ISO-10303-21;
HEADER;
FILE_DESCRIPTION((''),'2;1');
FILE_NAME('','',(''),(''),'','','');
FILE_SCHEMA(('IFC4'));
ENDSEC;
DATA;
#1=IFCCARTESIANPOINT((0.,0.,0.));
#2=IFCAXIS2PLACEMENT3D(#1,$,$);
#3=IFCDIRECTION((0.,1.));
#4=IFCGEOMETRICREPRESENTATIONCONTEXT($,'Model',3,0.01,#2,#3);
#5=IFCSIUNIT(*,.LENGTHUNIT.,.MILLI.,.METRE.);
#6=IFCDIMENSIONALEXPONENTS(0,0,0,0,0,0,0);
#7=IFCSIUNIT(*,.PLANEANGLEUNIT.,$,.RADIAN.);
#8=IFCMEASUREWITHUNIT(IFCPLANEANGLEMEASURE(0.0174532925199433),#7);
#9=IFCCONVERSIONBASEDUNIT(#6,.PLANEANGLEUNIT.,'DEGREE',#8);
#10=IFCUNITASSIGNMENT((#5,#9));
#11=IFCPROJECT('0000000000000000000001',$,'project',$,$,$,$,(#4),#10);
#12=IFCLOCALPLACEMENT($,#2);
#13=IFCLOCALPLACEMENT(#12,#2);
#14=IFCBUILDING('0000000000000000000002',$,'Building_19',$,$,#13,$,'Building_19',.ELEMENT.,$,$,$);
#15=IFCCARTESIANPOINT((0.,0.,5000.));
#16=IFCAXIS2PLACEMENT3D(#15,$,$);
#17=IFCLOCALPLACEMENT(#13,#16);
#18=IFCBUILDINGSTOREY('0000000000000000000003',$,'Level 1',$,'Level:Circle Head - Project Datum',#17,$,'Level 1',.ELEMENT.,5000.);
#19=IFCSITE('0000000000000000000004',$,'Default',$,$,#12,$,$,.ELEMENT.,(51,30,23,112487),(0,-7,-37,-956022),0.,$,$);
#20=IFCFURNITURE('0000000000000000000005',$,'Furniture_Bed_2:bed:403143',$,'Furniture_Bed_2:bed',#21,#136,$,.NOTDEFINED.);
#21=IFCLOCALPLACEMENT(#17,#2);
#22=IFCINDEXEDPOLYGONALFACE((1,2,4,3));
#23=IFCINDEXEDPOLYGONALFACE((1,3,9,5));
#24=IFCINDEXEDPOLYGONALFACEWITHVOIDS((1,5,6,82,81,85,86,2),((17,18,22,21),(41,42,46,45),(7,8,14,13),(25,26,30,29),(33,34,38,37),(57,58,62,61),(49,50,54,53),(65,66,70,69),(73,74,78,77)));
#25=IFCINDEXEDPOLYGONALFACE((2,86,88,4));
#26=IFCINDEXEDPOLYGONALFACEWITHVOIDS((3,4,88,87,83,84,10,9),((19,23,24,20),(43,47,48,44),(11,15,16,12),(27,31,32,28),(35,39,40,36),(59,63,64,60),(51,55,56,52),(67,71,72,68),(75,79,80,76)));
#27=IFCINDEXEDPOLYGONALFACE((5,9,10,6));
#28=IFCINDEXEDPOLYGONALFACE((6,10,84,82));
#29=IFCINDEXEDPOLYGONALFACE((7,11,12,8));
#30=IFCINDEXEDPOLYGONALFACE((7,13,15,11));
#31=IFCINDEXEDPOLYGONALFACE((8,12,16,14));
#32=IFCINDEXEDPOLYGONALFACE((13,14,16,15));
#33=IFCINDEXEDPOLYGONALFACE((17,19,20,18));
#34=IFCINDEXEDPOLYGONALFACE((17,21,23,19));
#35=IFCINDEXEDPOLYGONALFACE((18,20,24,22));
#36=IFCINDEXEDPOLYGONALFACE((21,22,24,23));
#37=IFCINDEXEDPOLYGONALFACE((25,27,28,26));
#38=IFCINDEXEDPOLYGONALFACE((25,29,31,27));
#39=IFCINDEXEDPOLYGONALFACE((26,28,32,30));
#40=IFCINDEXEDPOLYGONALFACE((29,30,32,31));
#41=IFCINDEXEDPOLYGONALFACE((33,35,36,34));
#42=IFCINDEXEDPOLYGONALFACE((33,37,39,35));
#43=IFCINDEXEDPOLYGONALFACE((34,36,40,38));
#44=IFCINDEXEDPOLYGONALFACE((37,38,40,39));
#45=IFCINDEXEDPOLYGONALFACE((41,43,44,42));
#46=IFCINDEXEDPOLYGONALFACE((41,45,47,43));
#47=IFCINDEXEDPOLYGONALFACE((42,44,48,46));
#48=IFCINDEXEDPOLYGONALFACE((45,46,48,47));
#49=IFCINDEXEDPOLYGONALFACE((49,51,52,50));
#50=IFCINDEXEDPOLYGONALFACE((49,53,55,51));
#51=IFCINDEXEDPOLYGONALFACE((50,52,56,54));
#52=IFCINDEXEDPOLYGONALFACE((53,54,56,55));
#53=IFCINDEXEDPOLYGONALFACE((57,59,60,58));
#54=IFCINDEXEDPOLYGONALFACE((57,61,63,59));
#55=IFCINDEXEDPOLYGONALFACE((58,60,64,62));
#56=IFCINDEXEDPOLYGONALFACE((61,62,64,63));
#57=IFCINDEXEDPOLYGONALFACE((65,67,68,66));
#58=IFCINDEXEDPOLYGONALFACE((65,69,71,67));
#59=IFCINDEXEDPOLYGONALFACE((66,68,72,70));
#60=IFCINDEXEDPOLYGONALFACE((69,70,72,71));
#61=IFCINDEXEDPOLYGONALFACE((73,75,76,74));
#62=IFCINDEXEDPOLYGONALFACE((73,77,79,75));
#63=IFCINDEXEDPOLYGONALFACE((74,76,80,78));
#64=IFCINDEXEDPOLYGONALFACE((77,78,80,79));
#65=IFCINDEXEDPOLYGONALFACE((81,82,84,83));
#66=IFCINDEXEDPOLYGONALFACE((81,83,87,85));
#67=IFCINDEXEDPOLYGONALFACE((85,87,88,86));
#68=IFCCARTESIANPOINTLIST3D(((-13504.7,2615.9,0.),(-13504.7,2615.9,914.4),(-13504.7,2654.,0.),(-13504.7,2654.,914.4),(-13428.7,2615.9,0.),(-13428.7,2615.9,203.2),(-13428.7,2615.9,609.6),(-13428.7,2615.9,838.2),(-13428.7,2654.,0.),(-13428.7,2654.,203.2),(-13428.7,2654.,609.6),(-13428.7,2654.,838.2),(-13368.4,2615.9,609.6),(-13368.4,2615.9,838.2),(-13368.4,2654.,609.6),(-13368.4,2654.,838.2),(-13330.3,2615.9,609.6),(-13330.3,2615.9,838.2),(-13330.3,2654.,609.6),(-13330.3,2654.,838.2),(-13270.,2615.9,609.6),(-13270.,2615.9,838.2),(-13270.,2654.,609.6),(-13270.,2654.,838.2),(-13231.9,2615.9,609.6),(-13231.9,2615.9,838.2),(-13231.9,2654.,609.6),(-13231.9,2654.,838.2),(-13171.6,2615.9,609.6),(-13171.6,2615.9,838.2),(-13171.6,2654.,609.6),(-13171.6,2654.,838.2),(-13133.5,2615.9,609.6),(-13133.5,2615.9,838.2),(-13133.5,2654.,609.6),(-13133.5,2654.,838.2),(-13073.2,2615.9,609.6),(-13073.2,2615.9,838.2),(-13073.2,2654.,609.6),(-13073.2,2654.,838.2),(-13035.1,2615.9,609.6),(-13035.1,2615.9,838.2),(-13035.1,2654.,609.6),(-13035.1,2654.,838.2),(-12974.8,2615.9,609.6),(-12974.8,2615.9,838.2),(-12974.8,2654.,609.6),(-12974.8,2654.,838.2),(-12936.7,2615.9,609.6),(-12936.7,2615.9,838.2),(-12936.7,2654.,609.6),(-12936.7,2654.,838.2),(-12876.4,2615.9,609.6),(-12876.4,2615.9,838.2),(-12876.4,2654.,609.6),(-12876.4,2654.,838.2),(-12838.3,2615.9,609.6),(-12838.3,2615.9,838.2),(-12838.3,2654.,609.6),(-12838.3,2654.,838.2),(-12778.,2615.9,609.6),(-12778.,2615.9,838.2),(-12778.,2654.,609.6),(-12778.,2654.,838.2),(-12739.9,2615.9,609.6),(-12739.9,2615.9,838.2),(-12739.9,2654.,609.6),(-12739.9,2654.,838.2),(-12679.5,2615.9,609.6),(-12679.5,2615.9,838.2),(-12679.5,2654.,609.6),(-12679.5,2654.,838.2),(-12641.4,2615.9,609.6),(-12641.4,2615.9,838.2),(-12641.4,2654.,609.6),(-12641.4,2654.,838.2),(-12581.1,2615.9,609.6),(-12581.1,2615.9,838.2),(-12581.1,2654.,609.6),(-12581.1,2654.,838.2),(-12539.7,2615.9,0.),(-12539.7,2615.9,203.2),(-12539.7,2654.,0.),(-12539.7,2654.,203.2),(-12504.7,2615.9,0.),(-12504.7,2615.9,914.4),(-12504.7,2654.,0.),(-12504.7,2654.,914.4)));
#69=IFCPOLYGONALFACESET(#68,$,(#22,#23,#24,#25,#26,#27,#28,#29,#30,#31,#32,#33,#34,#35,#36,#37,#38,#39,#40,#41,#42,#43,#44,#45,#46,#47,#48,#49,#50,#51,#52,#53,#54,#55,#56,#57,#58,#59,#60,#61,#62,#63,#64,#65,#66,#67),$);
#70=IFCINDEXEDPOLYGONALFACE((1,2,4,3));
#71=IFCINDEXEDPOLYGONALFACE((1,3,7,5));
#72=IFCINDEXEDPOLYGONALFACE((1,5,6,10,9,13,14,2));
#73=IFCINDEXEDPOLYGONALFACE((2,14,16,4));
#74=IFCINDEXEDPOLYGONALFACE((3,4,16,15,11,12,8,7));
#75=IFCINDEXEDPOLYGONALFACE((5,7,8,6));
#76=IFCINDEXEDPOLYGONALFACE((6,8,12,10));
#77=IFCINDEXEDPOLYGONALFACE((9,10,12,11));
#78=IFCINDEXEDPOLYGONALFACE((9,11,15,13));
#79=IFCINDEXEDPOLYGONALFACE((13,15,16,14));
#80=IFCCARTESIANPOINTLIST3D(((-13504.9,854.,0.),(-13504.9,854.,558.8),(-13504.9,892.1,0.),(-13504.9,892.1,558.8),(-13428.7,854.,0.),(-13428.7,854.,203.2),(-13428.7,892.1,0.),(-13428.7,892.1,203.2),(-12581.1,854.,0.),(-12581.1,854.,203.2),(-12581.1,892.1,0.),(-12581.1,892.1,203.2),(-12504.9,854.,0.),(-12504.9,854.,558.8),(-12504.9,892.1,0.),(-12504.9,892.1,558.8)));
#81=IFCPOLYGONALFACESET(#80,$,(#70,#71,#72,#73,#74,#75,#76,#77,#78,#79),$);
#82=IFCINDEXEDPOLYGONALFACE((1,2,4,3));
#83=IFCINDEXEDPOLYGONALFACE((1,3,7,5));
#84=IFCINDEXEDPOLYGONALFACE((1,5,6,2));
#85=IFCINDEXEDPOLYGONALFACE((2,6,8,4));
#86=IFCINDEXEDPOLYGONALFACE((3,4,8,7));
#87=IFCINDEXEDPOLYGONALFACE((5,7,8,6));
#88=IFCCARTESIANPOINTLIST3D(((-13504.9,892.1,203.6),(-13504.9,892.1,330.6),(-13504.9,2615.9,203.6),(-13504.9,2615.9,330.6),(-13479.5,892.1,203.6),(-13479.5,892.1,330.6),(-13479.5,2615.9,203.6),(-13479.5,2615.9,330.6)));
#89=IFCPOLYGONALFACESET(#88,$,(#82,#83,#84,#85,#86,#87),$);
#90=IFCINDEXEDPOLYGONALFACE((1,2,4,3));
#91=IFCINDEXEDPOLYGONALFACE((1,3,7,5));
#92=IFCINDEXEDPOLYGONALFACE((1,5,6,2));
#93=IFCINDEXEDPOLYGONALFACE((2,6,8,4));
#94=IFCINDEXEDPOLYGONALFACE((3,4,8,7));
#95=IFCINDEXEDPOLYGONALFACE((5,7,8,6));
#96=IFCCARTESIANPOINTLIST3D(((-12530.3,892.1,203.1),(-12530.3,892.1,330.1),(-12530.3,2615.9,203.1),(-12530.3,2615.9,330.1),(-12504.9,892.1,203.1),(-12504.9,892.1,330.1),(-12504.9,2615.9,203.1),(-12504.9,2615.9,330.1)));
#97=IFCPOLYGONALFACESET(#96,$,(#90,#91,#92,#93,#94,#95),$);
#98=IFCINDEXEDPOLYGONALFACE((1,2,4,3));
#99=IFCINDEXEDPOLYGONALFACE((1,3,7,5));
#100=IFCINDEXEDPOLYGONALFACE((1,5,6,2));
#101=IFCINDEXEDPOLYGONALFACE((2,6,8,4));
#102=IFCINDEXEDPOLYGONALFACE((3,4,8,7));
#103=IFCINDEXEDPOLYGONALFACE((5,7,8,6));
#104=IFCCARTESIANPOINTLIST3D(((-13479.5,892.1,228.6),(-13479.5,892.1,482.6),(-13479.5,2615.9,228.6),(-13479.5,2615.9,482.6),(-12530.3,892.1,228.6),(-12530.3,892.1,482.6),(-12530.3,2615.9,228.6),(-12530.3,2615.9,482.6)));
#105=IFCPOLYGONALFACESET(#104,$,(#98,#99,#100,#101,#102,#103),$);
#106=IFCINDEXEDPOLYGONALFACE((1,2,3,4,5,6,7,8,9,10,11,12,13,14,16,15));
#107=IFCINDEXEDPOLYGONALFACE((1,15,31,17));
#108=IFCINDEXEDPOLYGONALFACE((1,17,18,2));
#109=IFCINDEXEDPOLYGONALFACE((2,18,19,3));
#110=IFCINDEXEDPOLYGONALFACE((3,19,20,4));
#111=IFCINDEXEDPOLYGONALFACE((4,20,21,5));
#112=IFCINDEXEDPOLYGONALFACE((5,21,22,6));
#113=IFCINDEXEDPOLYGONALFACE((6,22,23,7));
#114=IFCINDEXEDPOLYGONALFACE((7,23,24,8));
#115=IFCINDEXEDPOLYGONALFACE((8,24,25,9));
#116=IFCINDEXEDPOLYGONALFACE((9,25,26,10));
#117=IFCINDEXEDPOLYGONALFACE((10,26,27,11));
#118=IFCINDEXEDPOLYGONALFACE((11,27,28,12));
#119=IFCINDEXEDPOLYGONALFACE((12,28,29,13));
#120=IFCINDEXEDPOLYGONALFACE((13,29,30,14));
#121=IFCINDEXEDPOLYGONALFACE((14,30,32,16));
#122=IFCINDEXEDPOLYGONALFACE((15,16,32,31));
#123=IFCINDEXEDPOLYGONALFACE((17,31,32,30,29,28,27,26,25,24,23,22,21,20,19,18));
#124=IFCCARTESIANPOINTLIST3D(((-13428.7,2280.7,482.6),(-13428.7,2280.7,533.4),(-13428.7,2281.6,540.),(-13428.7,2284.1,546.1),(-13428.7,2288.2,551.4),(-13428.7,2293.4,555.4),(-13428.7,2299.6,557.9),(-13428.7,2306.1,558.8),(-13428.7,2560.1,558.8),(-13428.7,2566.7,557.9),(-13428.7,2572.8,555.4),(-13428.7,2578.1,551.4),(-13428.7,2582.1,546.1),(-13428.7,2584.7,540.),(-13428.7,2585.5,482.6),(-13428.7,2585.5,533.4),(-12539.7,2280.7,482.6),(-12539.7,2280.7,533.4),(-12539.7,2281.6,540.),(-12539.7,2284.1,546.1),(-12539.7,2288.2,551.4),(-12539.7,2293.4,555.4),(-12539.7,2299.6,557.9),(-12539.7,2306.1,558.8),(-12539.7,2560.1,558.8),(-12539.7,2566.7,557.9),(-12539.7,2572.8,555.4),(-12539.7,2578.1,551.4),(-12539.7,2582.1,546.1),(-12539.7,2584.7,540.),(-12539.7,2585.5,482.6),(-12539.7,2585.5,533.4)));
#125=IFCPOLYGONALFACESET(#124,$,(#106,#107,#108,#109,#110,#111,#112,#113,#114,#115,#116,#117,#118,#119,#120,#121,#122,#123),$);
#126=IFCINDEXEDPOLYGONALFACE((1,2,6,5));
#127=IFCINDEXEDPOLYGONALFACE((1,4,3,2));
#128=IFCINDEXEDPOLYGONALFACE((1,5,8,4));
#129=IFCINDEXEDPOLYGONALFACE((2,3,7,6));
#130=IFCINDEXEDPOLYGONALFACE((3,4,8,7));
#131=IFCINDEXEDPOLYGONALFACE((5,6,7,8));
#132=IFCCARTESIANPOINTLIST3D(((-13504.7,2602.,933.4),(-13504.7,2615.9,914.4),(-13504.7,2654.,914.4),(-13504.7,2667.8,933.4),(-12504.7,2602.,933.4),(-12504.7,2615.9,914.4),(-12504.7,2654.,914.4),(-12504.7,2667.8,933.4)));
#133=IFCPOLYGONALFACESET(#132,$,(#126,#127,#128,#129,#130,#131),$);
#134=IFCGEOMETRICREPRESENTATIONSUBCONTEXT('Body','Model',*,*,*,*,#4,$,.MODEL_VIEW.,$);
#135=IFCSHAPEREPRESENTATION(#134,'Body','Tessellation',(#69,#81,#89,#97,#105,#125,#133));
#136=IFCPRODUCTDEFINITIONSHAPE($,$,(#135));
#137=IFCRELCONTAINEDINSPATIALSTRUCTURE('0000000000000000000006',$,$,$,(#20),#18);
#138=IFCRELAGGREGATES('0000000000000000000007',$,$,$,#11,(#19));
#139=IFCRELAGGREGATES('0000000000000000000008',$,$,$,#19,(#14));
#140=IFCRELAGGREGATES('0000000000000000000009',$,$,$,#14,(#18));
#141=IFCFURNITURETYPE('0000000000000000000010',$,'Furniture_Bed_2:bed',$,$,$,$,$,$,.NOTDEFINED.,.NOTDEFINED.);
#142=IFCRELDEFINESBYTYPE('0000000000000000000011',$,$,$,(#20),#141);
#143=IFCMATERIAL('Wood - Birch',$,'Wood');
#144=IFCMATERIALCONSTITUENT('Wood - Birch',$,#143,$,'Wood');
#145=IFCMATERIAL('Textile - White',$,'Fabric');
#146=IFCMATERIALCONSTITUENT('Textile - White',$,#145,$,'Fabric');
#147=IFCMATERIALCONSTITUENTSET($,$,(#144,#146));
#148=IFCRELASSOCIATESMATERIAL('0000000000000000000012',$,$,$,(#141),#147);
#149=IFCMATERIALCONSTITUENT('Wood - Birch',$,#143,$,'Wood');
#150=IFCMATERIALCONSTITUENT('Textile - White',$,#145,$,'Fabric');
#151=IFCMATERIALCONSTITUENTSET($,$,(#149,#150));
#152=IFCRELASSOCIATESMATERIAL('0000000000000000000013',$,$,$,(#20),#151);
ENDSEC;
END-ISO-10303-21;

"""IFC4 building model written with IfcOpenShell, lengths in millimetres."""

from ifc_helpers import new_model, entity, si_unit, converted_unit, direction, frame, origin, place, context, subcontext, project, spatial, line, arc, indexed_curve, outline, extrude, source, transform, mapped, material, constituent, constituent_set, type_object, type_shapes, element, save


model = new_model("IFC4")

# Units and contexts
model_context = context("Model", 3, precision=0.01, world=origin(), true_north=direction((0.0, 1.0)))
body_context = subcontext(model_context, "Body", "Model", "MODEL_VIEW")
ifc_project = project(units=[si_unit("LENGTHUNIT", "METRE", prefix="MILLI"), converted_unit("PLANEANGLEUNIT", "DEGREE", entity("IfcPlaneAngleMeasure", 0.0174532925199433), si_unit("PLANEANGLEUNIT", "RADIAN"), dimensions=[0, 0, 0, 0, 0, 0, 0])], contexts=[model_context])

# Site, building, storey
site_placement = place(None, origin())
site = spatial("IfcSite", under=ifc_project, at=site_placement, Name="Default", CompositionType="ELEMENT", RefLatitude=(51, 30, 23, 112487), RefLongitude=(0, -7, -37, -956022), RefElevation=0.0)
building_placement = place(site_placement, origin())
building = spatial("IfcBuilding", under=site, at=building_placement, Name="Building_19", LongName="Building_19", CompositionType="ELEMENT")
storey_placement = place(building_placement, frame((0.0, 0.0, 5000.0)))
storey = spatial("IfcBuildingStorey", under=building, at=storey_placement, Name="Level 1", ObjectType="Level:Circle Head - Project Datum", LongName="Level 1", CompositionType="ELEMENT", Elevation=5000.0)

# Furniture
ifc_material_1 = material(Name="Wood - Birch", Category="Wood")
ifc_constituent_1 = constituent(ifc_material_1, Name="Wood - Birch", Category="Wood")
ifc_material_2 = material(Name="Textile - White", Category="Fabric")
ifc_constituent_2 = constituent(ifc_material_2, Name="Textile - White", Category="Fabric")
ifc_constituent_set_1 = constituent_set(constituents=[ifc_constituent_1, ifc_constituent_2])
ifc_constituent_3 = constituent(ifc_material_1, Name="Wood - Birch", Category="Wood")
ifc_constituent_4 = constituent(ifc_material_2, Name="Textile - White", Category="Fabric")
ifc_constituent_set_2 = constituent_set(constituents=[ifc_constituent_3, ifc_constituent_4])
furniture_type_1 = type_object("IfcFurnitureType", Name="Furniture_Bed_2:bed", AssemblyPlace="NOTDEFINED", PredefinedType="NOTDEFINED", material=ifc_constituent_set_2)
shared_shape_1 = source(origin(), body_context, "Body", "SweptSolid", [
    extrude(outline(indexed_curve([(-635.0, -489.8), (279.4, -489.8), (279.4, -454.7), (76.2, -454.7), (76.2, 434.3), (279.4, 434.3), (279.4, 510.3), (-635.0, 510.3), (-635.0, -489.8)], self_intersect=False), holes=[indexed_curve([(-558.8, 374.0), (-558.8, 434.3), (-330.2, 434.3), (-330.2, 374.0), (-558.8, 374.0)], self_intersect=False), indexed_curve([(-558.8, 275.5), (-558.8, 335.9), (-330.2, 335.9), (-330.2, 275.5), (-558.8, 275.5)], self_intersect=False), indexed_curve([(-558.8, 177.1), (-558.8, 237.4), (-330.2, 237.4), (-330.2, 177.1), (-558.8, 177.1)], self_intersect=False), indexed_curve([(-558.8, 78.7), (-558.8, 139.0), (-330.2, 139.0), (-330.2, 78.7), (-558.8, 78.7)], self_intersect=False), indexed_curve([(-558.8, -118.1), (-558.8, -57.8), (-330.2, -57.8), (-330.2, -118.1), (-558.8, -118.1)], self_intersect=False), indexed_curve([(-558.8, -216.5), (-558.8, -156.2), (-330.2, -156.2), (-330.2, -216.5), (-558.8, -216.5)], self_intersect=False), indexed_curve([(-558.8, -314.9), (-558.8, -254.6), (-330.2, -254.6), (-330.2, -314.9), (-558.8, -314.9)], self_intersect=False), indexed_curve([(-558.8, -413.3), (-558.8, -353.0), (-330.2, -353.0), (-330.2, -413.3), (-558.8, -413.3)], self_intersect=False), indexed_curve([(-558.8, -19.7), (-558.8, 40.6), (-330.2, 40.6), (-330.2, -19.7), (-558.8, -19.7)], self_intersect=False)]), frame((-8.6, -38.1, 279.4), z_axis=(0.0, 1.0, 0.0), x_axis=(0.0, 0.0, -1.0)), (0.0, 0.0, 1.0), 38.1),
    extrude(outline(indexed_curve([(423.8, -190.5), (500.0, -190.5), (500.0, 368.3), (-500.0, 368.3), (-500.0, -190.5), (-423.8, -190.5), (-423.8, 12.7), (423.8, 12.7), (423.8, -190.5)], self_intersect=False)), frame((-19.1, -1800.0, 190.5), z_axis=(0.0, 1.0, 0.0), x_axis=(-1.0, 0.0, 0.0)), (0.0, 0.0, 1.0), 38.1),
    extrude(outline(indexed_curve([(-12.7, -861.9), (12.7, -861.9), (12.7, 861.9), (-12.7, 861.9), (-12.7, -861.9)], self_intersect=False)), frame((-506.4, -900.0, 203.6)), (0.0, 0.0, 1.0), 127.0),
    extrude(outline(indexed_curve([(-12.7, -861.9), (12.7, -861.9), (12.7, 861.9), (-12.7, 861.9), (-12.7, -861.9)], self_intersect=False)), frame((468.2, -900.0, 203.1)), (0.0, 0.0, 1.0), 127.0),
    extrude(outline(indexed_curve([(-474.6, -861.9), (474.6, -861.9), (474.6, 861.9), (-474.6, 861.9), (-474.6, -861.9)], self_intersect=False)), frame((-19.0, -900.0, 228.6), z_axis=(0.0, 0.0, 1.0), x_axis=(-1.0, 0.0, 0.0)), (0.0, 0.0, 1.0), 254.0),
    extrude(outline(indexed_curve([(-152.4, -42.3), (152.4, -42.3), (152.4, 8.5), (145.0, 26.4), (127.0, 33.9), (-127.0, 33.9), (-145.0, 26.4), (-152.4, 8.5)], segments=[line(1, 2, 3), arc(3, 4, 5), line(5, 6), arc(6, 7, 8), line(8, 1)], self_intersect=False)), frame((-442.9, -220.8, 524.9), z_axis=(1.0, 0.0, 0.0), x_axis=(0.0, 1.0, 0.0)), (0.0, 0.0, 1.0), 889.0),
    extrude(outline(indexed_curve([(-19.1, -9.5), (19.0, -9.5), (32.9, 9.5), (-32.9, 9.5), (-19.1, -9.5)], self_intersect=False)), frame((-518.8, -19.0, 923.9), z_axis=(1.0, 0.0, 0.0), x_axis=(0.0, 1.0, 0.0)), (0.0, 0.0, 1.0), 1000.1),
])
type_shapes(furniture_type_1, [shared_shape_1])
furniture_1_placement = place(storey_placement, frame((-12985.9, 2654.0, 0.0)))
element("IfcFurniture", 1, at=furniture_1_placement, inside=storey, type_object=furniture_type_1, material=ifc_constituent_set_1, Name="Furniture_Bed_2:bed:403143", ObjectType="Furniture_Bed_2:bed", PredefinedType="NOTDEFINED", context=body_context, shape_type="MappedRepresentation", body=[
    mapped(shared_shape_1, transform((0.0, 0.0, 0.0), scale=1.0)),
])

save(model, "model.ifc")
